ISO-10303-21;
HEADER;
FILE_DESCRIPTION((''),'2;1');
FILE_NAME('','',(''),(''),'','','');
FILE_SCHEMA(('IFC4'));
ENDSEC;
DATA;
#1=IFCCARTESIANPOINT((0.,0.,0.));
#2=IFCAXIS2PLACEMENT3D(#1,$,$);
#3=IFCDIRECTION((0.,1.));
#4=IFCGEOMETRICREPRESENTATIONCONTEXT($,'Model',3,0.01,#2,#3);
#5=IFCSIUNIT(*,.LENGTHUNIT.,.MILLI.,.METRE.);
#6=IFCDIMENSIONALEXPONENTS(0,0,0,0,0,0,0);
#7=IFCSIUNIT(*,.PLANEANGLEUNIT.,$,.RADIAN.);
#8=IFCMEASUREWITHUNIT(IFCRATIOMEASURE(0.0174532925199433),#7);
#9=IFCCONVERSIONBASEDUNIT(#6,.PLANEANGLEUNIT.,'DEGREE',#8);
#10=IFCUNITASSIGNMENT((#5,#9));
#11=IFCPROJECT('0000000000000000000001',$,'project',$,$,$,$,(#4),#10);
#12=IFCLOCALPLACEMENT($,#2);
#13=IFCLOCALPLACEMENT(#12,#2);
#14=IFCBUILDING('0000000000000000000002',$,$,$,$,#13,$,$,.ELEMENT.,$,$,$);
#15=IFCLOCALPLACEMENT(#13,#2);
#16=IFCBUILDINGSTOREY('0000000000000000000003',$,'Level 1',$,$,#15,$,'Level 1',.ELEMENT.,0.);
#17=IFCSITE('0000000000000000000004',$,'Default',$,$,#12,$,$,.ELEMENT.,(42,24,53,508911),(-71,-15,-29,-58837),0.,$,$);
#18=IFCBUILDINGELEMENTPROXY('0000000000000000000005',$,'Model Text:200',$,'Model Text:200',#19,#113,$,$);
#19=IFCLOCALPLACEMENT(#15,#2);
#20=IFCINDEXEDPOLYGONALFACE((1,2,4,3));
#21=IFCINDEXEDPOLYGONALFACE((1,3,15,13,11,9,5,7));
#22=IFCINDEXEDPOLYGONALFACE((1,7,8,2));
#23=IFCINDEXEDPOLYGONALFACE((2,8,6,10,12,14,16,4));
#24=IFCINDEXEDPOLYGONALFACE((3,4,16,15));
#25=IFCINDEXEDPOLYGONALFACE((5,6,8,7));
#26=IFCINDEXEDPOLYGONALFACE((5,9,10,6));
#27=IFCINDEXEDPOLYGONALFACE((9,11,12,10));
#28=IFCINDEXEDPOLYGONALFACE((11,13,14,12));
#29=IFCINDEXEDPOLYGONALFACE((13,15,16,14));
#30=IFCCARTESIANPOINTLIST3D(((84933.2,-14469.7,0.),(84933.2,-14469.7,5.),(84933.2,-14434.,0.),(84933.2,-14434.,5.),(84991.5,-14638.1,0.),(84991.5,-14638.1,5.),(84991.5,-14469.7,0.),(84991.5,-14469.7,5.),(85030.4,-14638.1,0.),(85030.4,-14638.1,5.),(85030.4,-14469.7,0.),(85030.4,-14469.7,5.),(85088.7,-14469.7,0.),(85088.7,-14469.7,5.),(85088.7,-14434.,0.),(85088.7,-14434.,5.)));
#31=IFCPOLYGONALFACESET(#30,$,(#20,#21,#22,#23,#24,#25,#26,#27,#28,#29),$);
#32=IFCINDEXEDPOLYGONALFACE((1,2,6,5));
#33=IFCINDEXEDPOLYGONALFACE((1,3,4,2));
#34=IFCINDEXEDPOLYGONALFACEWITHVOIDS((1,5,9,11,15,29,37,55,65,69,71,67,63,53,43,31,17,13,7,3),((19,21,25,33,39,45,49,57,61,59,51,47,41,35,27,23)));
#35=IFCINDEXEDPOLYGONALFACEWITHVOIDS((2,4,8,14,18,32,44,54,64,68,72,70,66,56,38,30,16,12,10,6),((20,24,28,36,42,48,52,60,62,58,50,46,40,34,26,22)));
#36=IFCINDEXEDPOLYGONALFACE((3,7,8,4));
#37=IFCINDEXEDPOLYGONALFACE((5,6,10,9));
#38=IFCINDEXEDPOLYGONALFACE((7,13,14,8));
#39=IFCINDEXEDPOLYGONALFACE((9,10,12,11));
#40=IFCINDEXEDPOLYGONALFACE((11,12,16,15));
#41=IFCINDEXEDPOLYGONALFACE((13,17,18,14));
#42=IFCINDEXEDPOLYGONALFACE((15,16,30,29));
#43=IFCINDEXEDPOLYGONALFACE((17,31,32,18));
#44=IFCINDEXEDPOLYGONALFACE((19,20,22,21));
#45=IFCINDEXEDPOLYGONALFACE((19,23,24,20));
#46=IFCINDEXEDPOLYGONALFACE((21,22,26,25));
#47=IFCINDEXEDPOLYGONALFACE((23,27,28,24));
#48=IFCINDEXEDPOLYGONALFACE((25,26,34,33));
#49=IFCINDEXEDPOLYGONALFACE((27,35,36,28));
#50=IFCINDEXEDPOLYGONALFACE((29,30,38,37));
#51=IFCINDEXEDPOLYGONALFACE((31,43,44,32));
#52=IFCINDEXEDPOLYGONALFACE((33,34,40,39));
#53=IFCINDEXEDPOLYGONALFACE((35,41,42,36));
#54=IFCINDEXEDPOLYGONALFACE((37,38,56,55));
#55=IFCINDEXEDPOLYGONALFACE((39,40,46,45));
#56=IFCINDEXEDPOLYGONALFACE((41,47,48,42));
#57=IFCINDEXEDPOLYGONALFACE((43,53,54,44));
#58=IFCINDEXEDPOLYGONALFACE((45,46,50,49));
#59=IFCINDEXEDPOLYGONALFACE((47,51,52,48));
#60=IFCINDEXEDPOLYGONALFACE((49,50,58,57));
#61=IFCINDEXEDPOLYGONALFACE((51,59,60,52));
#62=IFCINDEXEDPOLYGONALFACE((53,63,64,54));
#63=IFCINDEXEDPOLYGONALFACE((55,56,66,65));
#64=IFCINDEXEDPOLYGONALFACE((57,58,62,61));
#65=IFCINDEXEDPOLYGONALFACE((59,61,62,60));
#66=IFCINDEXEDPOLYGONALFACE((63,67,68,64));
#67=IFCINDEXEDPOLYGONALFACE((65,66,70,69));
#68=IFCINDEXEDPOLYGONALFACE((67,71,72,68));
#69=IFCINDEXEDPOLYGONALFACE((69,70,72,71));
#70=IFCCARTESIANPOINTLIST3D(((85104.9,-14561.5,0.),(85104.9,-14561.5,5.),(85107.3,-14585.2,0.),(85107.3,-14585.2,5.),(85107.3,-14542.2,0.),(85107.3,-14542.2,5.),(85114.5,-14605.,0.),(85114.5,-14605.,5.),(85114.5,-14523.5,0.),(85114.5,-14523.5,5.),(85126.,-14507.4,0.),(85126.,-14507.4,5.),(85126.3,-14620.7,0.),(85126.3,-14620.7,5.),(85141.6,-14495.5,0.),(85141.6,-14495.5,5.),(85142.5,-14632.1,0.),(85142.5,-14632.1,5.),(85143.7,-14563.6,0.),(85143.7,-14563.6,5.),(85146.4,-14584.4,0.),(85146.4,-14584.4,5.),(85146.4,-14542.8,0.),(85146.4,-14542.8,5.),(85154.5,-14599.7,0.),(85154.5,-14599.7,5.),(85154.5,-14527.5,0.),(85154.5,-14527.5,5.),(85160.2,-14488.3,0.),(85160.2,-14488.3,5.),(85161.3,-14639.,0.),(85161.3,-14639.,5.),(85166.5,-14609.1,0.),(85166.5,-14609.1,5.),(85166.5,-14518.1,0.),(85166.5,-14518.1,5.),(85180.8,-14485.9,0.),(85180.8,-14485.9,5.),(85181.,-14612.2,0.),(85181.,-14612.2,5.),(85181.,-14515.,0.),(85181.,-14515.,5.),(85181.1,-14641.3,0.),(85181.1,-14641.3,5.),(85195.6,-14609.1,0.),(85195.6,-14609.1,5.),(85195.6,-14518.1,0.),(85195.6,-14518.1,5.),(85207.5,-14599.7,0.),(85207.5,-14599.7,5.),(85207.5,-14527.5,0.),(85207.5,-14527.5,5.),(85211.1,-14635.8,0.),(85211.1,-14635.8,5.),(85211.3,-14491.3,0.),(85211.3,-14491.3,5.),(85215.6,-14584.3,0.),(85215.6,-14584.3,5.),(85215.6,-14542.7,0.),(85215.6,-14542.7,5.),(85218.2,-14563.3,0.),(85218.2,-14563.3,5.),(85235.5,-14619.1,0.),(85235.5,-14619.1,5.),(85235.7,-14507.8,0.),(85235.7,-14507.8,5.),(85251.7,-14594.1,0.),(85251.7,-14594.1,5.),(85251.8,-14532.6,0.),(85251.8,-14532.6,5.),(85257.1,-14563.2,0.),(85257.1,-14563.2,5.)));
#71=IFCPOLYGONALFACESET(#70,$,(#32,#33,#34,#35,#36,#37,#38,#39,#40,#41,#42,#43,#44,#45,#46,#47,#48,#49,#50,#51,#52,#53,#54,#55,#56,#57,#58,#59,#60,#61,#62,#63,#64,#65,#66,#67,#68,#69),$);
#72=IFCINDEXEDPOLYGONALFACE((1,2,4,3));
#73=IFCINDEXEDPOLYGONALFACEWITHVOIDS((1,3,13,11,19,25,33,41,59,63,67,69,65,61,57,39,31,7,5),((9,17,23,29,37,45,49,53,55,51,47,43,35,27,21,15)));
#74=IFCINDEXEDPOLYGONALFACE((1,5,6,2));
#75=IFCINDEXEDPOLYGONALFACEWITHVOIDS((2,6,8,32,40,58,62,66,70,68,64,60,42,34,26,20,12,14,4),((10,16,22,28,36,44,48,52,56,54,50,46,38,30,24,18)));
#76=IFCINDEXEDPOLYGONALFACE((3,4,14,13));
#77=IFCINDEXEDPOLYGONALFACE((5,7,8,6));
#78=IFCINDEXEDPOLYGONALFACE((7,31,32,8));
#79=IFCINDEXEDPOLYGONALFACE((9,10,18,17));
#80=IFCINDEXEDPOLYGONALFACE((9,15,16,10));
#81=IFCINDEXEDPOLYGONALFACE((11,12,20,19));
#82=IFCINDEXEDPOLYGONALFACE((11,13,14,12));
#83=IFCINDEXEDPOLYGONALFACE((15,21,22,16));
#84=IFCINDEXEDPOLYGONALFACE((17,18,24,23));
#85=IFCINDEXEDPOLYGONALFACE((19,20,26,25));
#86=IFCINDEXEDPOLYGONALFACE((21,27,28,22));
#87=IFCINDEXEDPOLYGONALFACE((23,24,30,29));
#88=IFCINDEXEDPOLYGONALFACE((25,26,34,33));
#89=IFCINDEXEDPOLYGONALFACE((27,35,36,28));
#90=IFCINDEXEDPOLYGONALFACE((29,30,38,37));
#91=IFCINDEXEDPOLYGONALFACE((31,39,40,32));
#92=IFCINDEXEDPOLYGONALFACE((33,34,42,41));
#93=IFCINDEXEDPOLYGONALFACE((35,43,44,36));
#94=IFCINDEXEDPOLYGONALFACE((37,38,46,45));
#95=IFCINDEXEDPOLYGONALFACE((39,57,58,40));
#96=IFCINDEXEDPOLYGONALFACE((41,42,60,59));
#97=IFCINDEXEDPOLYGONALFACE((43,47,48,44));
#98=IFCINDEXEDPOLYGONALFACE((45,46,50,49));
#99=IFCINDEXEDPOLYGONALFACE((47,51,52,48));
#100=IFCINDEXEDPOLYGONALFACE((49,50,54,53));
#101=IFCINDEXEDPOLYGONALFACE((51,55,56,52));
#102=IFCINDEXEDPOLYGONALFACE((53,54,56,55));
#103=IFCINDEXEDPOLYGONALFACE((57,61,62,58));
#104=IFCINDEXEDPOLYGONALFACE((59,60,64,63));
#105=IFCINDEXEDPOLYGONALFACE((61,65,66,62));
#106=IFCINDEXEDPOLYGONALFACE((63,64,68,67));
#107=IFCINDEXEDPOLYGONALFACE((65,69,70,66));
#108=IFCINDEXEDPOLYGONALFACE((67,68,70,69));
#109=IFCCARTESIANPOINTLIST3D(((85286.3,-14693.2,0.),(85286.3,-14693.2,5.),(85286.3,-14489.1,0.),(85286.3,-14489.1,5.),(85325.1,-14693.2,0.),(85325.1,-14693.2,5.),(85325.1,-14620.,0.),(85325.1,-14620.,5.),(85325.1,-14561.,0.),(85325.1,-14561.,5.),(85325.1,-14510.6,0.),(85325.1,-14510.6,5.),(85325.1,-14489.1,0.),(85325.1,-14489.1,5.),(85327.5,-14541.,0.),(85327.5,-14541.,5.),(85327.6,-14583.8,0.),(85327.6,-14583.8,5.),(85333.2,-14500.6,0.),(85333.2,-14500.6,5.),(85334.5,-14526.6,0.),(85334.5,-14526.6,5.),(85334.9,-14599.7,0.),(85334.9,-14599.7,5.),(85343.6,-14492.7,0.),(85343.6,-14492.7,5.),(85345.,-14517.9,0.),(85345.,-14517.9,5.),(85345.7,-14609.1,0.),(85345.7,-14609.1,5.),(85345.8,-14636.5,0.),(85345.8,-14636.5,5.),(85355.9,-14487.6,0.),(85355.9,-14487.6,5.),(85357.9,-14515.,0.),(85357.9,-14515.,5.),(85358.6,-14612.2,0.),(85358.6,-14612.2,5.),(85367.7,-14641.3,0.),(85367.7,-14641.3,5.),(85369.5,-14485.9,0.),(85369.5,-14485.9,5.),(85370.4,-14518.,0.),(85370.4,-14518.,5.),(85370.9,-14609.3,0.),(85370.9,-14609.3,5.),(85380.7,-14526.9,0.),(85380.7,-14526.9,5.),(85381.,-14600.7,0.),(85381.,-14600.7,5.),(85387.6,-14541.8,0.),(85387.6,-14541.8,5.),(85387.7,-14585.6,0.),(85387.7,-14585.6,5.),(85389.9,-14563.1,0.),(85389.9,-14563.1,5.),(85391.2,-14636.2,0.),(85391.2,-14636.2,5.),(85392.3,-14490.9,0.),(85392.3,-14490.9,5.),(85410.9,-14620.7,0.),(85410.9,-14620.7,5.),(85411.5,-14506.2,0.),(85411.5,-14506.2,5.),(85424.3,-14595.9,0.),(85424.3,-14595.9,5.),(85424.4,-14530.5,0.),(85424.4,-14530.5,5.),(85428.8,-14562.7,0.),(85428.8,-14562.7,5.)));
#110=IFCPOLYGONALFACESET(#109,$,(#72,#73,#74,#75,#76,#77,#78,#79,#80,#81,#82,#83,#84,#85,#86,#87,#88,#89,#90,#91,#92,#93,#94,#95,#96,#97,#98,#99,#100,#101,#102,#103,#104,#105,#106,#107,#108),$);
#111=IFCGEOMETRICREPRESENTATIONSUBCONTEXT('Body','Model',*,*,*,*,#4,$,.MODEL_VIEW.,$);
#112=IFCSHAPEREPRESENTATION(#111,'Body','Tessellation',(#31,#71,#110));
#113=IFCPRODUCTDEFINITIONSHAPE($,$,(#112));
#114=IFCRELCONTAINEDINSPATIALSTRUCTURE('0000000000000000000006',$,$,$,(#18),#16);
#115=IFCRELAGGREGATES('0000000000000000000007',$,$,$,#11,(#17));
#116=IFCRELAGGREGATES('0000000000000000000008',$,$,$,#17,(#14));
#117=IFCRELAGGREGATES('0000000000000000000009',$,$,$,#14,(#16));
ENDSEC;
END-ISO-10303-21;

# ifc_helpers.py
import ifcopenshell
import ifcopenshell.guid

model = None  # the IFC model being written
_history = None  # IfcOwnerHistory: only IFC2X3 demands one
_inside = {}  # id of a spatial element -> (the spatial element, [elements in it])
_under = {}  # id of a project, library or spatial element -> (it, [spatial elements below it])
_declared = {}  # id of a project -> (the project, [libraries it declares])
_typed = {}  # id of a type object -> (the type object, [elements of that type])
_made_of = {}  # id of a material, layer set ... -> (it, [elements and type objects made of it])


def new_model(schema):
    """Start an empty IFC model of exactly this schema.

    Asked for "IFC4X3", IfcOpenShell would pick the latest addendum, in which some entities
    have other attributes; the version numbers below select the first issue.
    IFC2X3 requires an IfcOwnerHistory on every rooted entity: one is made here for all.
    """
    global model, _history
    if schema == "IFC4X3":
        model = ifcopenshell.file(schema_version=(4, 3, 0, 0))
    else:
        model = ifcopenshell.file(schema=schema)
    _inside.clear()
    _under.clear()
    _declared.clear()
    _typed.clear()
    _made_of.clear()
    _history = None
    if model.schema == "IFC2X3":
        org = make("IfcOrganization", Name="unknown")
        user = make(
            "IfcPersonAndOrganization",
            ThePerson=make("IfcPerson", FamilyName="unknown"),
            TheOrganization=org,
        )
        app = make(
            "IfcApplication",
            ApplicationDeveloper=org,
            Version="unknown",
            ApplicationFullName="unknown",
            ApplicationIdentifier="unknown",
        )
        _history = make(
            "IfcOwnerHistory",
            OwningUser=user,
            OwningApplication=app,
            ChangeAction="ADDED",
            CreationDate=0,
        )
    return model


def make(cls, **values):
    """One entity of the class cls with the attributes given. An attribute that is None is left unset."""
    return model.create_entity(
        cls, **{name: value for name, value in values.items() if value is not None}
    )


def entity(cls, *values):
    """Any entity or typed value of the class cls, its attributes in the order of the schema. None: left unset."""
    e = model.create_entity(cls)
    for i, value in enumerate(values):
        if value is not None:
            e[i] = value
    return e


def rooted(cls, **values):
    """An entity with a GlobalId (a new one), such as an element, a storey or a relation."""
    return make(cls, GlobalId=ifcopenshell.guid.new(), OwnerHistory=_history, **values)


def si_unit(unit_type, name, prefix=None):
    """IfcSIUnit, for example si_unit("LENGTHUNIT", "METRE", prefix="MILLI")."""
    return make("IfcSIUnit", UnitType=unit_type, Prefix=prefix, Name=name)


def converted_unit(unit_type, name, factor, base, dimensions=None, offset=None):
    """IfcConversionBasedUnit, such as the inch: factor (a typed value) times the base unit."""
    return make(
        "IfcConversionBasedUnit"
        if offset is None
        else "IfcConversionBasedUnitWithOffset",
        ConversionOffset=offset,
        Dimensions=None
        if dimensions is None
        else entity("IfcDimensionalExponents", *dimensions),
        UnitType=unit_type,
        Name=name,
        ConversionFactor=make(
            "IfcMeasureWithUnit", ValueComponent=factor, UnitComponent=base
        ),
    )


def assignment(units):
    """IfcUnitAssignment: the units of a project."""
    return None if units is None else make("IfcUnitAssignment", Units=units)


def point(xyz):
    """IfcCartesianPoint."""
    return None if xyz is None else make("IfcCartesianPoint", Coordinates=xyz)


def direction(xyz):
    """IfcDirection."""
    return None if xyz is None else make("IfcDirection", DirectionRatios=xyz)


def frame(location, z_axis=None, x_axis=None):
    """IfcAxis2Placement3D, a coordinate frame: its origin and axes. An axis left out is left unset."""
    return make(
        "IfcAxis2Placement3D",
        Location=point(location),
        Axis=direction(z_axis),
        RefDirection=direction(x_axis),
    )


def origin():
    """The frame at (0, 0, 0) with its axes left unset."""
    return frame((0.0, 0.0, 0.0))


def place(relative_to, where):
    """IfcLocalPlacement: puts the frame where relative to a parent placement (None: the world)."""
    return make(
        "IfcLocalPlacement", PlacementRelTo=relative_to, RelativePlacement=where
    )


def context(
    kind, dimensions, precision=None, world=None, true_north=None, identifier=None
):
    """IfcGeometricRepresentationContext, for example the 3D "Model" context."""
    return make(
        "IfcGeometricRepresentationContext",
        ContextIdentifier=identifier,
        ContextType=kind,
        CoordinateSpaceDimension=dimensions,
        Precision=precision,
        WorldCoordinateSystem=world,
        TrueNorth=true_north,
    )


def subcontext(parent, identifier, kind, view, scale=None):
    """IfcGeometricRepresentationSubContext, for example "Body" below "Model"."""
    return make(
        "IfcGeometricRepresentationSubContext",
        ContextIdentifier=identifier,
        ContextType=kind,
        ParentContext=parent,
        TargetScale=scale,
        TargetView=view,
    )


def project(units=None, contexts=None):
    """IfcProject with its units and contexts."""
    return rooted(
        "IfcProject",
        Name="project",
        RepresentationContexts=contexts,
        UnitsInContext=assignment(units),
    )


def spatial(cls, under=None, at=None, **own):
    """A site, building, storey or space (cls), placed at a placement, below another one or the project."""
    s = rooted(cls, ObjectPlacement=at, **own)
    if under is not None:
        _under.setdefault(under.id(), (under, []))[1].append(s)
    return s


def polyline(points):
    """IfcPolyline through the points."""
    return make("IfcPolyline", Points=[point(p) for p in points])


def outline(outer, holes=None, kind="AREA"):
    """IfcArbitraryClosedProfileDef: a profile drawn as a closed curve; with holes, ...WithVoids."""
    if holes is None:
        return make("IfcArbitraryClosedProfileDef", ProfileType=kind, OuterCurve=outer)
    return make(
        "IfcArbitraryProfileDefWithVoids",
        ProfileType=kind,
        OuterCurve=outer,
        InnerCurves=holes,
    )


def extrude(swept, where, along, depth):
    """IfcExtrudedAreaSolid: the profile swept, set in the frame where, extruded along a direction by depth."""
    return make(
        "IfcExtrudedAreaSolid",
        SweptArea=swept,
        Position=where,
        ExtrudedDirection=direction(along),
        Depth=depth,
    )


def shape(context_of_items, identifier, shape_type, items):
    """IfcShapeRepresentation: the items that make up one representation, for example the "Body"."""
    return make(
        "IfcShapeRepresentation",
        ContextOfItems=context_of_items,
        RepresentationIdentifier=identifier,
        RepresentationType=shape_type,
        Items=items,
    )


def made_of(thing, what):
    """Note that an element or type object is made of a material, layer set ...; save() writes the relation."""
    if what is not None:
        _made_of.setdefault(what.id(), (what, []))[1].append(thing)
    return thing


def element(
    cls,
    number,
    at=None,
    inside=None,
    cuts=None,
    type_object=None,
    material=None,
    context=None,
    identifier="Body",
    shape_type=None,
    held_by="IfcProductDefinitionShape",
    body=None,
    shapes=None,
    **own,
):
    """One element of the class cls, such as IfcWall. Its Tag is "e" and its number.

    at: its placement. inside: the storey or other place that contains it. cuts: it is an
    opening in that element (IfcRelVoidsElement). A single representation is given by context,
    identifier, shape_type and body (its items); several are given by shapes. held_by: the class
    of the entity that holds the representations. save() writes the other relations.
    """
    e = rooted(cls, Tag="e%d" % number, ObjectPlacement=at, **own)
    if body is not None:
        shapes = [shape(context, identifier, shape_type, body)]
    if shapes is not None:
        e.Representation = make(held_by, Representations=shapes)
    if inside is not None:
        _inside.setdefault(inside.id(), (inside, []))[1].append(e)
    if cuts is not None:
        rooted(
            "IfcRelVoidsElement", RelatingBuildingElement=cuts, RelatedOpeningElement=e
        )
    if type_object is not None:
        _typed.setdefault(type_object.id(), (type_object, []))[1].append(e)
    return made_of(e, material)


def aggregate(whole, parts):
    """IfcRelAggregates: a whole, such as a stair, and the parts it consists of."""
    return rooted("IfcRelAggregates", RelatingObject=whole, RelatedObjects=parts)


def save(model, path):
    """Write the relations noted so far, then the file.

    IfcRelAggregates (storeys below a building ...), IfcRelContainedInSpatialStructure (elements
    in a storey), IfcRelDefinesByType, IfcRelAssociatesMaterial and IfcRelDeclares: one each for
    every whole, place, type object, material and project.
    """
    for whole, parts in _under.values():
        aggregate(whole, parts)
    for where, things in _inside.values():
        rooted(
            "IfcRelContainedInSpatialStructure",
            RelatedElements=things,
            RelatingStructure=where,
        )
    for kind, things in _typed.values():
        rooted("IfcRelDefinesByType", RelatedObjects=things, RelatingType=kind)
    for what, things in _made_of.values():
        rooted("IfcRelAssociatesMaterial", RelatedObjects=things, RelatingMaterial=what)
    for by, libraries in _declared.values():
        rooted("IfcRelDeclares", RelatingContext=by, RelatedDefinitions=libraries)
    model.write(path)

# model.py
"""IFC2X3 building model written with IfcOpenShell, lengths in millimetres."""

from ifc_helpers import new_model, entity, si_unit, converted_unit, direction, frame, origin, place, context, subcontext, project, spatial, polyline, outline, extrude, element, save


model = new_model("IFC2X3")

# Units and contexts
model_context = context("Model", 3, precision=0.01, world=origin(), true_north=direction((0.0, 1.0)))
body_context = subcontext(model_context, "Body", "Model", "MODEL_VIEW")
ifc_project = project(units=[si_unit("LENGTHUNIT", "METRE", prefix="MILLI"), converted_unit("PLANEANGLEUNIT", "DEGREE", entity("IfcRatioMeasure", 0.0174532925199433), si_unit("PLANEANGLEUNIT", "RADIAN"), dimensions=[0, 0, 0, 0, 0, 0, 0])], contexts=[model_context])

# Site, building, storey
site_placement = place(None, origin())
site = spatial("IfcSite", under=ifc_project, at=site_placement, Name="Default", CompositionType="ELEMENT", RefLatitude=(42, 24, 53, 508911), RefLongitude=(-71, -15, -29, -58837), RefElevation=0.0)
building_placement = place(site_placement, origin())
building = spatial("IfcBuilding", under=site, at=building_placement, CompositionType="ELEMENT")
storey_placement = place(building_placement, origin())
storey = spatial("IfcBuildingStorey", under=building, at=storey_placement, Name="Level 1", LongName="Level 1", CompositionType="ELEMENT", Elevation=0.0)

# Building element proxy
proxy_1_placement = place(storey_placement, origin())
element("IfcBuildingElementProxy", 1, at=proxy_1_placement, inside=storey, Name="Model Text:200", ObjectType="Model Text:200", context=body_context, shape_type="SweptSolid", body=[
    extrude(outline(polyline([(-19.4, -135.2), (19.4, -135.2), (19.4, 33.2), (77.7, 33.2), (77.7, 68.8), (-77.7, 68.8), (-77.7, 33.2), (-19.4, 33.2), (-19.4, -135.2)])), frame((85010.9, -14502.9, 0.0)), (0.0, 0.0, 1.0), 5.0),
    extrude(outline(polyline([(-8.8, -65.7), (15.1, -65.7), (35.5, -60.5), (52.3, -50.4), (65.3, -35.4), (74.1, -17.3), (78.4, 2.1), (75.9, 32.5), (61.8, 58.5), (38.4, 77.1), (8.3, 85.6), (-22.7, 83.3), (-49.0, 69.9), (-67.8, 47.3), (-76.3, 17.5), (-76.0, -3.3), (-70.7, -22.5), (-60.5, -39.2), (-45.5, -52.3), (-27.7, -61.4), (-8.8, -65.7)]), holes=[polyline([(-2.7, -27.2), (-23.1, -22.5), (-37.5, -12.9), (-45.7, 0.0), (-47.3, 14.8), (-42.7, 28.9), (-32.2, 39.9), (-16.3, 46.3), (4.5, 46.9), (25.1, 42.1), (39.6, 32.6), (47.7, 19.7), (49.4, 5.0), (44.8, -9.2), (34.2, -20.2), (18.2, -26.7), (-2.7, -27.2)])]), frame((85171.1, -14563.6, 0.0), z_axis=(0.0, 0.0, 1.0), x_axis=(0.100608, -0.994926, 0.0)), (0.0, 0.0, 1.0), 5.0),
    extrude(outline(polyline([(-73.1, -75.4), (130.9, -75.4), (130.9, -36.6), (57.8, -36.6), (74.3, -15.9), (79.1, 6.0), (73.9, 29.5), (58.4, 49.2), (33.6, 62.6), (0.5, 67.1), (-31.8, 62.8), (-56.1, 49.8), (-71.3, 30.7), (-76.4, 7.8), (-74.7, -5.8), (-69.6, -18.1), (-61.7, -28.5), (-51.7, -36.6), (-73.1, -36.6), (-73.1, -75.4)]), holes=[polyline([(-1.2, -36.6), (-21.2, -34.2), (-35.6, -27.2), (-44.3, -16.7), (-47.2, -3.8), (-44.3, 8.7), (-35.4, 19.0), (-20.4, 25.9), (0.8, 28.2), (23.3, 26.0), (38.5, 19.3), (47.1, 9.2), (49.9, -3.1), (46.8, -16.0), (37.4, -26.8), (21.5, -34.1), (-1.2, -36.6)])]), frame((85361.7, -14562.3, 0.0), z_axis=(0.0, 0.0, 1.0), x_axis=(0.0, -1.0, 0.0)), (0.0, 0.0, 1.0), 5.0),
])

save(model, "model.ifc")
